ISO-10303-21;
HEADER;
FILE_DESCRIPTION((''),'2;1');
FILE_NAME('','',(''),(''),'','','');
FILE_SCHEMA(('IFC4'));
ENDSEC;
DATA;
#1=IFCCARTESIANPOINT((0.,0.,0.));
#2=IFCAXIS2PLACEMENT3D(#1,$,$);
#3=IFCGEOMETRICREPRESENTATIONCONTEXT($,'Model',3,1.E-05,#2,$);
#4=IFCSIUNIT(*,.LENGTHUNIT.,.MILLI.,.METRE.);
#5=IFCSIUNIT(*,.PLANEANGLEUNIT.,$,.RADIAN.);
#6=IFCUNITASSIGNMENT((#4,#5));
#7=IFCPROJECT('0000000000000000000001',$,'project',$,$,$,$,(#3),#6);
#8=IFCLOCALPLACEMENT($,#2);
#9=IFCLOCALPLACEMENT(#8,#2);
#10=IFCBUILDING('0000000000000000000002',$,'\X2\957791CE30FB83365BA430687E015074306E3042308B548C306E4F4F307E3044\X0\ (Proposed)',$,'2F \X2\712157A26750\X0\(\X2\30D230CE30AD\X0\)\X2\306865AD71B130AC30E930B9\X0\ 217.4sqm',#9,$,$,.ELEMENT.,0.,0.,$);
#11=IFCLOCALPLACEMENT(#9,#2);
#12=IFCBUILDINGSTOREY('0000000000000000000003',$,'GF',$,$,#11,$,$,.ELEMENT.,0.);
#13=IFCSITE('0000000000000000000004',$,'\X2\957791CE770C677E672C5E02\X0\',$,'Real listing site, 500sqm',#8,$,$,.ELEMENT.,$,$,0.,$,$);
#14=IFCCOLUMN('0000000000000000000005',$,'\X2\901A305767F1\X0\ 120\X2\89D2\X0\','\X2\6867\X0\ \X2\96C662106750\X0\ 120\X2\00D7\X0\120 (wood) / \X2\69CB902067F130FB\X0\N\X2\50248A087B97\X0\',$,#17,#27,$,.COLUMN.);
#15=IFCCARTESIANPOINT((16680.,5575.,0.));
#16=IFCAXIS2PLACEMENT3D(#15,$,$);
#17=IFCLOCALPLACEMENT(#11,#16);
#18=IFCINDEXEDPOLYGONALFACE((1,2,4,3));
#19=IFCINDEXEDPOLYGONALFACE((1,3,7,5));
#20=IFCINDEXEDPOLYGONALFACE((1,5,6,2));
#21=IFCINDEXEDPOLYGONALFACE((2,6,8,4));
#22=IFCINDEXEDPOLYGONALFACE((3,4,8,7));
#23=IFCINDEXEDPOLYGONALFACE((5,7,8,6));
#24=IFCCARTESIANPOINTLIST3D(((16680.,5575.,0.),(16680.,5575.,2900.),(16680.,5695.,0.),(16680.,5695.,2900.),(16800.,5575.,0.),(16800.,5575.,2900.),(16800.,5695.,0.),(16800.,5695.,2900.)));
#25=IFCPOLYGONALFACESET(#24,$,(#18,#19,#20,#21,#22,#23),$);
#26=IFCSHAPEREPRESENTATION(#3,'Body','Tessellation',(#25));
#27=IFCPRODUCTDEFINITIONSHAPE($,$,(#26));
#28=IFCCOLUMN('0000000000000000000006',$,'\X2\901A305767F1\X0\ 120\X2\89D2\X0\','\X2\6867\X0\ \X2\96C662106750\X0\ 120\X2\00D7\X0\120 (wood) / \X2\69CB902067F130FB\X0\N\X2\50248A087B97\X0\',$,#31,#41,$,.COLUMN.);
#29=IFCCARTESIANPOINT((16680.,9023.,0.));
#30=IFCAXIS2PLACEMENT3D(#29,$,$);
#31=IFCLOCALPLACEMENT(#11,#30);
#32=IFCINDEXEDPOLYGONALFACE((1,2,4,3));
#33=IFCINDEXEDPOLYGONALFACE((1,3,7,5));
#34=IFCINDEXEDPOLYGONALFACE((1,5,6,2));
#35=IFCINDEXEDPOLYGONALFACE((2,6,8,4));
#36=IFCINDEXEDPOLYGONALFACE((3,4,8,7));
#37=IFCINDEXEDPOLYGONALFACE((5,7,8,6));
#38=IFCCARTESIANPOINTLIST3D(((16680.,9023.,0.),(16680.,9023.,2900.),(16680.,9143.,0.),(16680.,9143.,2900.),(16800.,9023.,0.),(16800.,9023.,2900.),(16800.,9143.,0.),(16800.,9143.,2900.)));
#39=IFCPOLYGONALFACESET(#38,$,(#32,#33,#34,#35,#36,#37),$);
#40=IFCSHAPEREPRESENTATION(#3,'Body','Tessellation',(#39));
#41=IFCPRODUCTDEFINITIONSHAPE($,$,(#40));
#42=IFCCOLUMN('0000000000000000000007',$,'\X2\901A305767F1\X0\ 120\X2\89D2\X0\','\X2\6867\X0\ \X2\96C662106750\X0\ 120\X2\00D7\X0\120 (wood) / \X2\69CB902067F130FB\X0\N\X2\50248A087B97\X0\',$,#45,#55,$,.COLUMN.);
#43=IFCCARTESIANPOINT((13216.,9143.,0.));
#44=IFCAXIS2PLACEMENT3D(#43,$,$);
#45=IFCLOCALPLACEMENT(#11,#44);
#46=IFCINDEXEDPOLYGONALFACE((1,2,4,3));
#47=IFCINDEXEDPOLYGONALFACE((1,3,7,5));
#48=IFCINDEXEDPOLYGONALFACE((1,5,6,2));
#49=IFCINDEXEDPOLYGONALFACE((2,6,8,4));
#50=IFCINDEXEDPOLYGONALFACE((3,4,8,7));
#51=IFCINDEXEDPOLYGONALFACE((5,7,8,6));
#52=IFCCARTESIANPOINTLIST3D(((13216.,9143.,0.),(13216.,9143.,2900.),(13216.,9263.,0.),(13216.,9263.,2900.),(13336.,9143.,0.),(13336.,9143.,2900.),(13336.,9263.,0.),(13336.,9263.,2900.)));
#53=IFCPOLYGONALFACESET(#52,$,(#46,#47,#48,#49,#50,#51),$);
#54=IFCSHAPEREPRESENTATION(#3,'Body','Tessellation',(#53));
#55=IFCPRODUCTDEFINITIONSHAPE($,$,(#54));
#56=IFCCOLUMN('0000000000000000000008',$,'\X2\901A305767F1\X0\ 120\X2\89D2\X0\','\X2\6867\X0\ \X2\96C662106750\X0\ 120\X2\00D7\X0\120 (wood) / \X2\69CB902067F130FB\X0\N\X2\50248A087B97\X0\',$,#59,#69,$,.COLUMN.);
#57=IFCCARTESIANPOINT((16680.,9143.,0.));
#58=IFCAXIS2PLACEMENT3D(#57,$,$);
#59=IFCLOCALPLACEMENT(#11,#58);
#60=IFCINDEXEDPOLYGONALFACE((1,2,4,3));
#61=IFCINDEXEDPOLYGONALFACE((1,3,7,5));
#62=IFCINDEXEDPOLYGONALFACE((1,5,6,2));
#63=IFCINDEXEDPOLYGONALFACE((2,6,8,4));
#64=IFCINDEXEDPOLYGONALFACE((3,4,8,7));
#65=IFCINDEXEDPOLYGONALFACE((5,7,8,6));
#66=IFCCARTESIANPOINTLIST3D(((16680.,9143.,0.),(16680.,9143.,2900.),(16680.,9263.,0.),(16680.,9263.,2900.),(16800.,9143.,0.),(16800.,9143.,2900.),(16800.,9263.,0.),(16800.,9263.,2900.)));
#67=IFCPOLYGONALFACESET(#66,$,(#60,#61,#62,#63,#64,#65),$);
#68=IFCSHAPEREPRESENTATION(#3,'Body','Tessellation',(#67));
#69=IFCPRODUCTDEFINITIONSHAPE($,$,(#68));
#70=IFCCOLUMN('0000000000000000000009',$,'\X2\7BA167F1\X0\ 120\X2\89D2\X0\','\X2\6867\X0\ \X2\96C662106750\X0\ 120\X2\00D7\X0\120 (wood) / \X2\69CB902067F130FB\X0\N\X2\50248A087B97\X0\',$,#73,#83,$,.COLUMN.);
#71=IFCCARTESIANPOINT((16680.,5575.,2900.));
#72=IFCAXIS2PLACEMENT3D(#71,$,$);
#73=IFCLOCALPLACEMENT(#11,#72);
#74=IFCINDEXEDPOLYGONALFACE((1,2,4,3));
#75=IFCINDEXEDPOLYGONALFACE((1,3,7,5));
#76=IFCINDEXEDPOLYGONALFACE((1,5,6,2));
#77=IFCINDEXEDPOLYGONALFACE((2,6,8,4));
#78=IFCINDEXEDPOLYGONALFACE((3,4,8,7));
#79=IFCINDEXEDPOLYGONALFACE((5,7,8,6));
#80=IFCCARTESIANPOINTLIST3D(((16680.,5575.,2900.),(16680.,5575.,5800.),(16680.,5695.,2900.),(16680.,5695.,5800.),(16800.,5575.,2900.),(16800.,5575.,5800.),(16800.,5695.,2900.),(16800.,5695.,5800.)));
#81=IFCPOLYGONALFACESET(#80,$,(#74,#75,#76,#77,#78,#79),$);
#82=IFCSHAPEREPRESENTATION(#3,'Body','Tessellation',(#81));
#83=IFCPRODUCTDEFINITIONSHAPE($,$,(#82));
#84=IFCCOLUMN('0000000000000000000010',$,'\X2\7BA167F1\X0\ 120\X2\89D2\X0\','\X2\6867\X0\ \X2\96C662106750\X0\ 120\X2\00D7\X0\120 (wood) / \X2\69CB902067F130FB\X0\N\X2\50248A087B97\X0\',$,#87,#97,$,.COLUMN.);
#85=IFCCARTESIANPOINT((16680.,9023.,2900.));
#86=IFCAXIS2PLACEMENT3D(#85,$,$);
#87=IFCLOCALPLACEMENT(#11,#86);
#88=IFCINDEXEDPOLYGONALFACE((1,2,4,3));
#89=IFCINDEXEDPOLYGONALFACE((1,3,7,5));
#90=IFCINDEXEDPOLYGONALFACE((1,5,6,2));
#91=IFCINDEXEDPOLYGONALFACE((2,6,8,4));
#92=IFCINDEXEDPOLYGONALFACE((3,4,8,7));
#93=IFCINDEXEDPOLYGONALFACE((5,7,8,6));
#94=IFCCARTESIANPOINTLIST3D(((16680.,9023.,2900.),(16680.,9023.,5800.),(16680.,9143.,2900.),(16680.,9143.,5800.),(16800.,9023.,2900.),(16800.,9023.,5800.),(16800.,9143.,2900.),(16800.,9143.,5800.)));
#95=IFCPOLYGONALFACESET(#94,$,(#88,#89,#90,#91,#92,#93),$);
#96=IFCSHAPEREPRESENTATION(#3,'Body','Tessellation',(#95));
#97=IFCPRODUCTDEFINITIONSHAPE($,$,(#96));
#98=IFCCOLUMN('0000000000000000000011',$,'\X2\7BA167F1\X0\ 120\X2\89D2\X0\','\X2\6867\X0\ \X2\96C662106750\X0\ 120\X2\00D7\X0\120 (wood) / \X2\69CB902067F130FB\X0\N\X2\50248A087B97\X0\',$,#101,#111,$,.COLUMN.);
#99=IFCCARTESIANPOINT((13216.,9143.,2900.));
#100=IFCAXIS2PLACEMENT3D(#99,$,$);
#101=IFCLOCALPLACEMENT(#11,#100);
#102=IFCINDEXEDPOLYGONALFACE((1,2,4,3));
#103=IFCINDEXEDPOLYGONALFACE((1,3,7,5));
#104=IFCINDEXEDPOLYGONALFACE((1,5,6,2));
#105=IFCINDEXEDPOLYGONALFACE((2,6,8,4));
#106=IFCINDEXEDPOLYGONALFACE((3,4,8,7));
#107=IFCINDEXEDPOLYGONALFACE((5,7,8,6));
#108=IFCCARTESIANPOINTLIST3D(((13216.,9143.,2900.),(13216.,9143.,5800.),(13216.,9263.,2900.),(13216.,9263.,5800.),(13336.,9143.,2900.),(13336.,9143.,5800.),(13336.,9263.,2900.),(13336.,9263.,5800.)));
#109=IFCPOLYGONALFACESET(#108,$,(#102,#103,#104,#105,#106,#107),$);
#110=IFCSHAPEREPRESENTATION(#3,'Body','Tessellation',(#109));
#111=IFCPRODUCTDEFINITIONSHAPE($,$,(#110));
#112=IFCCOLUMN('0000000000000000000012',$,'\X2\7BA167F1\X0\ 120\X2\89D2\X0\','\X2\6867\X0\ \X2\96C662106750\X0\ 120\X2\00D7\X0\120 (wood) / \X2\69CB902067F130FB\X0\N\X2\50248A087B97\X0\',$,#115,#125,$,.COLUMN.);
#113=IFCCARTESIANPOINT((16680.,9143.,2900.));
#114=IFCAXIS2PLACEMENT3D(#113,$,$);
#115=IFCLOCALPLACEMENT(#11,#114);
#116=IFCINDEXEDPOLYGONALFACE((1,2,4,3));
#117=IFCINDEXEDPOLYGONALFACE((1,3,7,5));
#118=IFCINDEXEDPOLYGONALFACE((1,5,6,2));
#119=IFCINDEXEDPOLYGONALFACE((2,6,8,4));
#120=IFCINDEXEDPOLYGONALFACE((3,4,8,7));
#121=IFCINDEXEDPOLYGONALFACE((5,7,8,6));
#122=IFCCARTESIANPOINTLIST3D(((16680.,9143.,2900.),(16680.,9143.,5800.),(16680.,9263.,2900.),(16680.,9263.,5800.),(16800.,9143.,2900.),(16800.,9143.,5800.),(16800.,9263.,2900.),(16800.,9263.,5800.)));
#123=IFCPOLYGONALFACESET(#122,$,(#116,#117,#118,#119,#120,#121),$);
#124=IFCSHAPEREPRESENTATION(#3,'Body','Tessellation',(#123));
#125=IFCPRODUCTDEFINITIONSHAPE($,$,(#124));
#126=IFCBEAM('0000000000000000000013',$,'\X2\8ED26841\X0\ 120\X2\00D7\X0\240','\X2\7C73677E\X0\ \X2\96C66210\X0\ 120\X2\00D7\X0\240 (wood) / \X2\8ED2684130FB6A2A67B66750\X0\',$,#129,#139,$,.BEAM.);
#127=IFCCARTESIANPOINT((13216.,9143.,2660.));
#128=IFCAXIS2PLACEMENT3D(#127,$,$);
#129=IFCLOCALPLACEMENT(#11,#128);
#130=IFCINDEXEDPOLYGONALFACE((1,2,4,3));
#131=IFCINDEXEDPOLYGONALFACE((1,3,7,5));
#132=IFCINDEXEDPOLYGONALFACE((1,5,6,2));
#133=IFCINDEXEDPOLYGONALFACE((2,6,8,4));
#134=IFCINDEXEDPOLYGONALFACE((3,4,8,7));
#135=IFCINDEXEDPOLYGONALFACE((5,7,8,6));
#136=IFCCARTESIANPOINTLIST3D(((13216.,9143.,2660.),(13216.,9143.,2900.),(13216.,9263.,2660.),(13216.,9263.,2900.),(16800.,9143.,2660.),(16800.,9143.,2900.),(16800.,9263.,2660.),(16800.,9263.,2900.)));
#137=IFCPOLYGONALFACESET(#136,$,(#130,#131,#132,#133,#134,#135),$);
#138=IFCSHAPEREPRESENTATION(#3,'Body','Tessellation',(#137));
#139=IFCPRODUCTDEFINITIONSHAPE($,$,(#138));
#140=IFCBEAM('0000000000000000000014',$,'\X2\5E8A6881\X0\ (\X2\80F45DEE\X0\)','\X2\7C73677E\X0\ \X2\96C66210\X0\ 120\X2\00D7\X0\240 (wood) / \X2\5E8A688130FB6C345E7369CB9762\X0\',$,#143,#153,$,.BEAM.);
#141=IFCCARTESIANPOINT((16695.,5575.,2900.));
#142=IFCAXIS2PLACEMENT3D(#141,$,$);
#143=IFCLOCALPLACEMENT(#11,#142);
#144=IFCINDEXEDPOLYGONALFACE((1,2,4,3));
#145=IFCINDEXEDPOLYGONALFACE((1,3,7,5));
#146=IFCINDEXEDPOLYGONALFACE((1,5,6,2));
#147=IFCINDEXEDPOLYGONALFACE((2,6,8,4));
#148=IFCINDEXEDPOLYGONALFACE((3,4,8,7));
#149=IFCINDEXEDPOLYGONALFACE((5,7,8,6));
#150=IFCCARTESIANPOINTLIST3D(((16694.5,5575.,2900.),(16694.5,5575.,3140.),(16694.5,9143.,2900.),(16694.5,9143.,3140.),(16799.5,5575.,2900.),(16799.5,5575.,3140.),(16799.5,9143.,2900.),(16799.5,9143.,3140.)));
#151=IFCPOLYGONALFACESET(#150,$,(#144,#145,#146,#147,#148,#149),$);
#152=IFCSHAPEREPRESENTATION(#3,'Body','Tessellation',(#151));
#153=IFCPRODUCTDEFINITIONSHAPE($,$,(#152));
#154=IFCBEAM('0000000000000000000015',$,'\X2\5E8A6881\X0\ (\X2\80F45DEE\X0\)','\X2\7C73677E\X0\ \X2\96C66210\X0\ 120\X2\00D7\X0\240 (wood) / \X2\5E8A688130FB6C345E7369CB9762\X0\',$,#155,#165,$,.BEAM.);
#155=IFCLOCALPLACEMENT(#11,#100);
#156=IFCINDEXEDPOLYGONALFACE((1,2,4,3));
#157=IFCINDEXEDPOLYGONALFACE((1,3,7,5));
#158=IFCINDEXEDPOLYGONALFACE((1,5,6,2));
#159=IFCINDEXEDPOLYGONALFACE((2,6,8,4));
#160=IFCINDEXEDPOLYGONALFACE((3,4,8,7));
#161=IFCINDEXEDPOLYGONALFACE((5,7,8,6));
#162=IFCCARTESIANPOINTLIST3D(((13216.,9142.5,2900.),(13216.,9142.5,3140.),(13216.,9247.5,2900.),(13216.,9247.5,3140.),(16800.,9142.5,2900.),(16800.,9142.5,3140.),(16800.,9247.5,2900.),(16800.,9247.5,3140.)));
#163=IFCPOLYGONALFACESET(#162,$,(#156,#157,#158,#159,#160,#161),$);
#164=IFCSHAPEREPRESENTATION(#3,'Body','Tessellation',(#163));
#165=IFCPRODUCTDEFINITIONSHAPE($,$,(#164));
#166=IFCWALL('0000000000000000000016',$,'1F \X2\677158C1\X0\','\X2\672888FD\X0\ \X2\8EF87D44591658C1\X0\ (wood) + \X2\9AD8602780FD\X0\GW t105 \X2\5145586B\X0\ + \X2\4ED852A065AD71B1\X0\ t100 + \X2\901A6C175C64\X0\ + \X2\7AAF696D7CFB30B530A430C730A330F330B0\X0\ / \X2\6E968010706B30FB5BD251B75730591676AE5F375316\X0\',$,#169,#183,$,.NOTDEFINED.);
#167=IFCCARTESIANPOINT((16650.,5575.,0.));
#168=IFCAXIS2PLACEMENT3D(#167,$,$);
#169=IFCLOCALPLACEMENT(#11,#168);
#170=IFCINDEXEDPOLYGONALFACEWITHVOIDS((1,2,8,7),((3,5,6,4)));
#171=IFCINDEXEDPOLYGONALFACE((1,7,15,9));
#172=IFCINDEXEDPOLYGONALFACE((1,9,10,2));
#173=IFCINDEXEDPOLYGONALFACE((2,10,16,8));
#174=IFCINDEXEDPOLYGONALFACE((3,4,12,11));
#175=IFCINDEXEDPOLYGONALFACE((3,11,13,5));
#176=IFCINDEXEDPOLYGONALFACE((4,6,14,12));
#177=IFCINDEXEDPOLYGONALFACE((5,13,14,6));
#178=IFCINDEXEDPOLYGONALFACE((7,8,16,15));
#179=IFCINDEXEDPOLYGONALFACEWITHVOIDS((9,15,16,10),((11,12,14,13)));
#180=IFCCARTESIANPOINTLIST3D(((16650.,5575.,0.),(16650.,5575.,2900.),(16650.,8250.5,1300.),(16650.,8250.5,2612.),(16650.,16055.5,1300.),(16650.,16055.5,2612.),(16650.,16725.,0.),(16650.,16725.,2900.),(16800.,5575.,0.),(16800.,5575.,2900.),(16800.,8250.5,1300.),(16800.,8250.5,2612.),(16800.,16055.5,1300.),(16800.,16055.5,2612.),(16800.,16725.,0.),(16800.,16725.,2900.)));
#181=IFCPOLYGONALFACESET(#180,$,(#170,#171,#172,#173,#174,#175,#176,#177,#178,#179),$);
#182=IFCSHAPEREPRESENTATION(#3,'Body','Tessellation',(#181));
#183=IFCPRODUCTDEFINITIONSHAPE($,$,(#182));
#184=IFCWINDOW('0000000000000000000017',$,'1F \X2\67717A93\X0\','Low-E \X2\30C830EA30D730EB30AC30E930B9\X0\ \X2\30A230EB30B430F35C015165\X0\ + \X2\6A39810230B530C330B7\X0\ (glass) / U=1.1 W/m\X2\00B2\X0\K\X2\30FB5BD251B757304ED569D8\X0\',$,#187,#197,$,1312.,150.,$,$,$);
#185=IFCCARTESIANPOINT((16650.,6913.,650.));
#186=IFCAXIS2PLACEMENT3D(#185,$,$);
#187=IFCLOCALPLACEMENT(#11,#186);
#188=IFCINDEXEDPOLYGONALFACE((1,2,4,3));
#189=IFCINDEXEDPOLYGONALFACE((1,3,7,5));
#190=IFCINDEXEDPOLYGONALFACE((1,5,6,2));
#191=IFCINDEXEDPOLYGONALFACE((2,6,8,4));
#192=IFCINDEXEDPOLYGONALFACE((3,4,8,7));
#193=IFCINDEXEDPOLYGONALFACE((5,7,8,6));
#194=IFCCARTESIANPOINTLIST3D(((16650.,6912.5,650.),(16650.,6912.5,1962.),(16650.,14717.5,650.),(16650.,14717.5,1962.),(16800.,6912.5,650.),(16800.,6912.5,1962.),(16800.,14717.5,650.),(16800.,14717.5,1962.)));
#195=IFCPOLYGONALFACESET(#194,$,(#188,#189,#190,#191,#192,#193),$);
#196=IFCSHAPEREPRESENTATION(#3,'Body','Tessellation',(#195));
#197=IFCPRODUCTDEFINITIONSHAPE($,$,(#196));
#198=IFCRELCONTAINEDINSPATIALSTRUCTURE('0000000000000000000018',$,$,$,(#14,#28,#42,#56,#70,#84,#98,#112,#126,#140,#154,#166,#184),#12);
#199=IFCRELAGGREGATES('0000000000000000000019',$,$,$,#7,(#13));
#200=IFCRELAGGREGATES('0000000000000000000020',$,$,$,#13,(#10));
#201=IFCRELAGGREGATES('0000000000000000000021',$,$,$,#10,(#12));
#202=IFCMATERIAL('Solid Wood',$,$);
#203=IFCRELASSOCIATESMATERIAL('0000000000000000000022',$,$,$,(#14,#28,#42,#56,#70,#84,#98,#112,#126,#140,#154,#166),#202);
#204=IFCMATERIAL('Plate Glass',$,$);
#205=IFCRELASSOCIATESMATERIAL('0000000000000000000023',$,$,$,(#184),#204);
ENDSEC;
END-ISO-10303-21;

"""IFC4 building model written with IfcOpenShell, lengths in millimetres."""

from ifc_helpers import new_model, si_unit, frame, frame_2d, origin, place, context, project, spatial, rectangle, extrude, material, element, fill, save


model = new_model("IFC4")

# Units and contexts
model_context = context("Model", 3, precision=1e-05, world=origin())
ifc_project = project(units=[si_unit("LENGTHUNIT", "METRE", prefix="MILLI"), si_unit("PLANEANGLEUNIT", "RADIAN")], contexts=[model_context])

# Site, building, storey
site_placement = place(None, origin())
site = spatial("IfcSite", under=ifc_project, at=site_placement, Name="長野県松本市", ObjectType="Real listing site, 500sqm", CompositionType="ELEMENT", RefElevation=0.0)
building_placement = place(site_placement, origin())
building = spatial("IfcBuilding", under=site, at=building_placement, Name="長野・茶室と縁側のある和の住まい (Proposed)", ObjectType="2F 無垢材(ヒノキ)と断熱ガラス 217.4sqm", CompositionType="ELEMENT", ElevationOfRefHeight=0.0, ElevationOfTerrain=0.0)
storey_placement = place(building_placement, origin())
storey = spatial("IfcBuildingStorey", under=building, at=storey_placement, Name="GF", CompositionType="ELEMENT", Elevation=0.0)

# Columns
ifc_material_1 = material(Name="Solid Wood")
column_1_placement = place(storey_placement, frame((16680.0, 5575.0, 0.0)))
element("IfcColumn", 1, at=column_1_placement, inside=storey, material=ifc_material_1, Name="通し柱 120角", Description="桧 集成材 120×120 (wood) / 構造柱・N値計算", PredefinedType="COLUMN", context=model_context, shape_type="SweptSolid", body=[
    extrude(rectangle(XDim=120.0, YDim=120.0, at=frame_2d((60.0, 60.0))), frame((16680.0, 5575.0, 0.0)), (0.0, 0.0, 1.0), 2900.0),
])
column_2_placement = place(storey_placement, frame((16680.0, 9023.0, 0.0)))
element("IfcColumn", 2, at=column_2_placement, inside=storey, material=ifc_material_1, Name="通し柱 120角", Description="桧 集成材 120×120 (wood) / 構造柱・N値計算", PredefinedType="COLUMN", context=model_context, shape_type="SweptSolid", body=[
    extrude(rectangle(XDim=120.0, YDim=120.0, at=frame_2d((60.0, 60.0))), frame((16680.0, 9023.0, 0.0)), (0.0, 0.0, 1.0), 2900.0),
])
column_3_placement = place(storey_placement, frame((13216.0, 9143.0, 0.0)))
element("IfcColumn", 3, at=column_3_placement, inside=storey, material=ifc_material_1, Name="通し柱 120角", Description="桧 集成材 120×120 (wood) / 構造柱・N値計算", PredefinedType="COLUMN", context=model_context, shape_type="SweptSolid", body=[
    extrude(rectangle(XDim=120.0, YDim=120.0, at=frame_2d((60.0, 60.0))), frame((13216.0, 9143.0, 0.0)), (0.0, 0.0, 1.0), 2900.0),
])
column_4_placement = place(storey_placement, frame((16680.0, 9143.0, 0.0)))
element("IfcColumn", 4, at=column_4_placement, inside=storey, material=ifc_material_1, Name="通し柱 120角", Description="桧 集成材 120×120 (wood) / 構造柱・N値計算", PredefinedType="COLUMN", context=model_context, shape_type="SweptSolid", body=[
    extrude(rectangle(XDim=120.0, YDim=120.0, at=frame_2d((60.0, 60.0))), frame((16680.0, 9143.0, 0.0)), (0.0, 0.0, 1.0), 2900.0),
])
column_5_placement = place(storey_placement, frame((16680.0, 5575.0, 2900.0)))
element("IfcColumn", 5, at=column_5_placement, inside=storey, material=ifc_material_1, Name="管柱 120角", Description="桧 集成材 120×120 (wood) / 構造柱・N値計算", PredefinedType="COLUMN", context=model_context, shape_type="SweptSolid", body=[
    extrude(rectangle(XDim=120.0, YDim=120.0, at=frame_2d((60.0, 60.0))), frame((16680.0, 5575.0, 2900.0)), (0.0, 0.0, 1.0), 2900.0),
])
column_6_placement = place(storey_placement, frame((16680.0, 9023.0, 2900.0)))
element("IfcColumn", 6, at=column_6_placement, inside=storey, material=ifc_material_1, Name="管柱 120角", Description="桧 集成材 120×120 (wood) / 構造柱・N値計算", PredefinedType="COLUMN", context=model_context, shape_type="SweptSolid", body=[
    extrude(rectangle(XDim=120.0, YDim=120.0, at=frame_2d((60.0, 60.0))), frame((16680.0, 9023.0, 2900.0)), (0.0, 0.0, 1.0), 2900.0),
])
column_7_placement = place(storey_placement, frame((13216.0, 9143.0, 2900.0)))
element("IfcColumn", 7, at=column_7_placement, inside=storey, material=ifc_material_1, Name="管柱 120角", Description="桧 集成材 120×120 (wood) / 構造柱・N値計算", PredefinedType="COLUMN", context=model_context, shape_type="SweptSolid", body=[
    extrude(rectangle(XDim=120.0, YDim=120.0, at=frame_2d((60.0, 60.0))), frame((13216.0, 9143.0, 2900.0)), (0.0, 0.0, 1.0), 2900.0),
])
column_8_placement = place(storey_placement, frame((16680.0, 9143.0, 2900.0)))
element("IfcColumn", 8, at=column_8_placement, inside=storey, material=ifc_material_1, Name="管柱 120角", Description="桧 集成材 120×120 (wood) / 構造柱・N値計算", PredefinedType="COLUMN", context=model_context, shape_type="SweptSolid", body=[
    extrude(rectangle(XDim=120.0, YDim=120.0, at=frame_2d((60.0, 60.0))), frame((16680.0, 9143.0, 2900.0)), (0.0, 0.0, 1.0), 2900.0),
])

# Beams
beam_1_placement = place(storey_placement, frame((13216.0, 9143.0, 2660.0)))
element("IfcBeam", 9, at=beam_1_placement, inside=storey, material=ifc_material_1, Name="軒桁 120×240", Description="米松 集成 120×240 (wood) / 軒桁・横架材", PredefinedType="BEAM", context=model_context, shape_type="SweptSolid", body=[
    extrude(rectangle(XDim=3584.0, YDim=120.0, at=frame_2d((1792.0, 60.0))), frame((13216.0, 9143.0, 2660.0)), (0.0, 0.0, 1.0), 240.0),
])
beam_2_placement = place(storey_placement, frame((16695.0, 5575.0, 2900.0)))
element("IfcBeam", 10, at=beam_2_placement, inside=storey, material=ifc_material_1, Name="床梁 (胴差)", Description="米松 集成 120×240 (wood) / 床梁・水平構面", PredefinedType="BEAM", context=model_context, shape_type="SweptSolid", body=[
    extrude(rectangle(XDim=105.0, YDim=3568.0, at=frame_2d((52.0, 1784.0))), frame((16695.0, 5575.0, 2900.0)), (0.0, 0.0, 1.0), 240.0),
])
beam_3_placement = place(storey_placement, frame((13216.0, 9143.0, 2900.0)))
element("IfcBeam", 11, at=beam_3_placement, inside=storey, material=ifc_material_1, Name="床梁 (胴差)", Description="米松 集成 120×240 (wood) / 床梁・水平構面", PredefinedType="BEAM", context=model_context, shape_type="SweptSolid", body=[
    extrude(rectangle(XDim=3584.0, YDim=105.0, at=frame_2d((1792.0, 52.0))), frame((13216.0, 9143.0, 2900.0)), (0.0, 0.0, 1.0), 240.0),
])

# Wall, opening, window
wall_1_placement = place(storey_placement, frame((16650.0, 5575.0, 0.0)))
wall_1 = element("IfcWall", 12, at=wall_1_placement, inside=storey, material=ifc_material_1, Name="1F 東壁", Description="木製 軸組外壁 (wood) + 高性能GW t105 充填 + 付加断熱 t100 + 通気層 + 窯業系サイディング / 準耐火・寒冷地外皮強化", PredefinedType="NOTDEFINED", context=model_context, shape_type="SweptSolid", body=[
    extrude(rectangle(XDim=150.0, YDim=11150.0, at=frame_2d((75.0, 5575.0))), frame((16650.0, 5575.0, 0.0)), (0.0, 0.0, 1.0), 2900.0),
])
opening_1_placement = place(storey_placement, frame((16650.0, 6913.0, 650.0)))
opening_1 = element("IfcOpeningElement", 13, at=opening_1_placement, cuts=wall_1, PredefinedType="NOTDEFINED", context=model_context, shape_type="SweptSolid", body=[
    extrude(rectangle(XDim=150.0, YDim=7805.0, at=frame_2d((75.0, 3902.0))), frame((16650.0, 6913.0, 650.0)), (0.0, 0.0, 1.0), 1312.0),
])
ifc_material_2 = material(Name="Plate Glass")
window_1_placement = place(storey_placement, frame((16650.0, 6913.0, 650.0)))
window_1 = element("IfcWindow", 14, at=window_1_placement, inside=storey, material=ifc_material_2, Name="1F 東窓", Description="Low-E トリプルガラス アルゴン封入 + 樹脂サッシ (glass) / U=1.1 W/m²K・寒冷地仕様", OverallHeight=1312.0, OverallWidth=150.0, context=model_context, shape_type="SweptSolid", body=[
    extrude(rectangle(XDim=150.0, YDim=7805.0, at=frame_2d((75.0, 3902.0))), frame((16650.0, 6913.0, 650.0)), (0.0, 0.0, 1.0), 1312.0),
])
fill(opening_1, window_1)

save(model, "model.ifc")
